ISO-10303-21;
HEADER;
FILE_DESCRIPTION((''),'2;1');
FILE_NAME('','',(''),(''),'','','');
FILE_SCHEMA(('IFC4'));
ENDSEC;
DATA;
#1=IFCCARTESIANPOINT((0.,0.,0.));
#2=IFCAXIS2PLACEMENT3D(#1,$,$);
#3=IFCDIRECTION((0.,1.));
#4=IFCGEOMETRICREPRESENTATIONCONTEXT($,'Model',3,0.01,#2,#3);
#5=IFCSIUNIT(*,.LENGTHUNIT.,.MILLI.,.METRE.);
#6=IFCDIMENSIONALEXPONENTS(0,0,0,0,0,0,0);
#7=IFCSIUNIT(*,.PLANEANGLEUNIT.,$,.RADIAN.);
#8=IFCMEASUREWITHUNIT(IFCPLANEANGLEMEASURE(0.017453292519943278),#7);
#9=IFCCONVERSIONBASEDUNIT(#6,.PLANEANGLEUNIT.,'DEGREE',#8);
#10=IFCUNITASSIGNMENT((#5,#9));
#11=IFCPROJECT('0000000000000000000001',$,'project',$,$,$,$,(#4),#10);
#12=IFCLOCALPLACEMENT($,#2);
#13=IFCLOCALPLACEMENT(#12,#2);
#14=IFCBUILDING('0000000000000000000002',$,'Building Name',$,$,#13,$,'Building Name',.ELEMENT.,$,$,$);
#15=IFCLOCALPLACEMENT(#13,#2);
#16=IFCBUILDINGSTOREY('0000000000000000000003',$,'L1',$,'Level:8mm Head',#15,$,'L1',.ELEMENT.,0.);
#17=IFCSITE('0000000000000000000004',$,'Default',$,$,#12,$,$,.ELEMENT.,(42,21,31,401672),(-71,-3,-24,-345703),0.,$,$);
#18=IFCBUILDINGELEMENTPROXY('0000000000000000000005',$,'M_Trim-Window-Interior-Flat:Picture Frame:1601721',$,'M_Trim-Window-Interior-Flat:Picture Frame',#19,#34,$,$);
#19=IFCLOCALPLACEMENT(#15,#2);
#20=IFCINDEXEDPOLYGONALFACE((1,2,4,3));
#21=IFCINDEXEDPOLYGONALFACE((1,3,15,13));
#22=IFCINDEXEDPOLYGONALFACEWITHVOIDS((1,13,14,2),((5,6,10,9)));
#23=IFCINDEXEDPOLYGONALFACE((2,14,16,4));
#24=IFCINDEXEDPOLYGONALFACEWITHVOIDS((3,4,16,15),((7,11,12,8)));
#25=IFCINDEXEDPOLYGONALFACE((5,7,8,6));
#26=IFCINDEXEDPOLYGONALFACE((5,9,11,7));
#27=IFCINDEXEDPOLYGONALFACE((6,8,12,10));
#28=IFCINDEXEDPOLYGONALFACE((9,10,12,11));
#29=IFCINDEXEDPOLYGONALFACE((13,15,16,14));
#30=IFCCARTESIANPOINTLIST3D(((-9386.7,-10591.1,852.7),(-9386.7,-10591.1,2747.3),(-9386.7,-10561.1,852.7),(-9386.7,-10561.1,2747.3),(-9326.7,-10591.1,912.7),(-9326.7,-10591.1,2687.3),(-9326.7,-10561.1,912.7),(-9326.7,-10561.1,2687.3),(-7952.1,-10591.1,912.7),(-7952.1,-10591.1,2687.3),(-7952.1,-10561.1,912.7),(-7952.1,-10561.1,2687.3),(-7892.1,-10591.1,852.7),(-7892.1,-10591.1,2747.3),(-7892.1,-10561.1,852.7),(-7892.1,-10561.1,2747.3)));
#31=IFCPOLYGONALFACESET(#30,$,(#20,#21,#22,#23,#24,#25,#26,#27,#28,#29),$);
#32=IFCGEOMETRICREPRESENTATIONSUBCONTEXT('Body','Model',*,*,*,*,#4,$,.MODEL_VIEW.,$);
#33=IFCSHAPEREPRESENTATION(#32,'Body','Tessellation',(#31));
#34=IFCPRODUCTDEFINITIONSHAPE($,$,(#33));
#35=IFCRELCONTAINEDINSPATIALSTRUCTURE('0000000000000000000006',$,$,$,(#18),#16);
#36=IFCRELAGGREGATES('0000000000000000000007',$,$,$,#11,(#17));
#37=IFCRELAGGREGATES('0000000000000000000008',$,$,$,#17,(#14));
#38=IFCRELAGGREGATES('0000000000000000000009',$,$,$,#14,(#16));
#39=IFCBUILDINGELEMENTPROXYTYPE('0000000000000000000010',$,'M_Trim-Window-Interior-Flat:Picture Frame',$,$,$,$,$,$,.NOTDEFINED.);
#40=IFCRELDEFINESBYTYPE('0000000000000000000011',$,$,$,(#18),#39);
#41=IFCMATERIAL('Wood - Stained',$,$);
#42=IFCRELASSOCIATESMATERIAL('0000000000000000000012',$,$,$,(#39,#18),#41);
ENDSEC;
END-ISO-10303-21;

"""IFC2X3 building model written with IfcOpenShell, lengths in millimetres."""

from ifc_helpers import new_model, entity, si_unit, converted_unit, direction, frame, origin, place, context, subcontext, project, spatial, polyline, outline, extrude, source, transform, mapped, material, type_object, type_shapes, element, save


model = new_model("IFC2X3")

# Units and contexts
model_context = context("Model", 3, precision=0.01, world=origin(), true_north=direction((0.0, 1.0)))
body_context = subcontext(model_context, "Body", "Model", "MODEL_VIEW")
ifc_project = project(units=[si_unit("LENGTHUNIT", "METRE", prefix="MILLI"), converted_unit("PLANEANGLEUNIT", "DEGREE", entity("IfcPlaneAngleMeasure", 0.017453292519943278), si_unit("PLANEANGLEUNIT", "RADIAN"), dimensions=[0, 0, 0, 0, 0, 0, 0])], contexts=[model_context])

# Site, building, storey
site_placement = place(None, origin())
site = spatial("IfcSite", under=ifc_project, at=site_placement, Name="Default", CompositionType="ELEMENT", RefLatitude=(42, 21, 31, 401672), RefLongitude=(-71, -3, -24, -345703), RefElevation=0.0)
building_placement = place(site_placement, origin())
building = spatial("IfcBuilding", under=site, at=building_placement, Name="Building Name", LongName="Building Name", CompositionType="ELEMENT")
storey_placement = place(building_placement, origin())
storey = spatial("IfcBuildingStorey", under=building, at=storey_placement, Name="L1", ObjectType="Level:8mm Head", LongName="L1", CompositionType="ELEMENT", Elevation=0.0)

# Building element proxy
ifc_material_1 = material(Name="Wood - Stained")
building_element_proxy_type_1 = type_object("IfcBuildingElementProxyType", Name="M_Trim-Window-Interior-Flat:Picture Frame", PredefinedType="NOTDEFINED", material=ifc_material_1)
shared_shape_1 = source(origin(), body_context, "Body", "SweptSolid", [
    extrude(outline(polyline([(-947.3, -747.3), (947.3, -747.3), (947.3, 747.3), (-947.3, 747.3), (-947.3, -747.3)]), holes=[polyline([(-887.3, -687.3), (-887.3, 687.3), (887.3, 687.3), (887.3, -687.3), (-887.3, -687.3)])]), frame((0.0, 900.0, 0.0), z_axis=(0.0, 0.0, 1.0), x_axis=(0.0, 1.0, 0.0)), (0.0, 0.0, 1.0), 30.0),
])
type_shapes(building_element_proxy_type_1, [shared_shape_1])
proxy_1_placement = place(storey_placement, frame((-8639.4, -10591.1, 2700.0), z_axis=(0.0, 1.0, 0.0), x_axis=(1.0, 0.0, 0.0)))
element("IfcBuildingElementProxy", 1, at=proxy_1_placement, inside=storey, type_object=building_element_proxy_type_1, material=ifc_material_1, Name="M_Trim-Window-Interior-Flat:Picture Frame:1601721", ObjectType="M_Trim-Window-Interior-Flat:Picture Frame", context=body_context, shape_type="MappedRepresentation", body=[
    mapped(shared_shape_1, transform((0.0, 0.0, 0.0), scale=1.0)),
])

save(model, "model.ifc")
